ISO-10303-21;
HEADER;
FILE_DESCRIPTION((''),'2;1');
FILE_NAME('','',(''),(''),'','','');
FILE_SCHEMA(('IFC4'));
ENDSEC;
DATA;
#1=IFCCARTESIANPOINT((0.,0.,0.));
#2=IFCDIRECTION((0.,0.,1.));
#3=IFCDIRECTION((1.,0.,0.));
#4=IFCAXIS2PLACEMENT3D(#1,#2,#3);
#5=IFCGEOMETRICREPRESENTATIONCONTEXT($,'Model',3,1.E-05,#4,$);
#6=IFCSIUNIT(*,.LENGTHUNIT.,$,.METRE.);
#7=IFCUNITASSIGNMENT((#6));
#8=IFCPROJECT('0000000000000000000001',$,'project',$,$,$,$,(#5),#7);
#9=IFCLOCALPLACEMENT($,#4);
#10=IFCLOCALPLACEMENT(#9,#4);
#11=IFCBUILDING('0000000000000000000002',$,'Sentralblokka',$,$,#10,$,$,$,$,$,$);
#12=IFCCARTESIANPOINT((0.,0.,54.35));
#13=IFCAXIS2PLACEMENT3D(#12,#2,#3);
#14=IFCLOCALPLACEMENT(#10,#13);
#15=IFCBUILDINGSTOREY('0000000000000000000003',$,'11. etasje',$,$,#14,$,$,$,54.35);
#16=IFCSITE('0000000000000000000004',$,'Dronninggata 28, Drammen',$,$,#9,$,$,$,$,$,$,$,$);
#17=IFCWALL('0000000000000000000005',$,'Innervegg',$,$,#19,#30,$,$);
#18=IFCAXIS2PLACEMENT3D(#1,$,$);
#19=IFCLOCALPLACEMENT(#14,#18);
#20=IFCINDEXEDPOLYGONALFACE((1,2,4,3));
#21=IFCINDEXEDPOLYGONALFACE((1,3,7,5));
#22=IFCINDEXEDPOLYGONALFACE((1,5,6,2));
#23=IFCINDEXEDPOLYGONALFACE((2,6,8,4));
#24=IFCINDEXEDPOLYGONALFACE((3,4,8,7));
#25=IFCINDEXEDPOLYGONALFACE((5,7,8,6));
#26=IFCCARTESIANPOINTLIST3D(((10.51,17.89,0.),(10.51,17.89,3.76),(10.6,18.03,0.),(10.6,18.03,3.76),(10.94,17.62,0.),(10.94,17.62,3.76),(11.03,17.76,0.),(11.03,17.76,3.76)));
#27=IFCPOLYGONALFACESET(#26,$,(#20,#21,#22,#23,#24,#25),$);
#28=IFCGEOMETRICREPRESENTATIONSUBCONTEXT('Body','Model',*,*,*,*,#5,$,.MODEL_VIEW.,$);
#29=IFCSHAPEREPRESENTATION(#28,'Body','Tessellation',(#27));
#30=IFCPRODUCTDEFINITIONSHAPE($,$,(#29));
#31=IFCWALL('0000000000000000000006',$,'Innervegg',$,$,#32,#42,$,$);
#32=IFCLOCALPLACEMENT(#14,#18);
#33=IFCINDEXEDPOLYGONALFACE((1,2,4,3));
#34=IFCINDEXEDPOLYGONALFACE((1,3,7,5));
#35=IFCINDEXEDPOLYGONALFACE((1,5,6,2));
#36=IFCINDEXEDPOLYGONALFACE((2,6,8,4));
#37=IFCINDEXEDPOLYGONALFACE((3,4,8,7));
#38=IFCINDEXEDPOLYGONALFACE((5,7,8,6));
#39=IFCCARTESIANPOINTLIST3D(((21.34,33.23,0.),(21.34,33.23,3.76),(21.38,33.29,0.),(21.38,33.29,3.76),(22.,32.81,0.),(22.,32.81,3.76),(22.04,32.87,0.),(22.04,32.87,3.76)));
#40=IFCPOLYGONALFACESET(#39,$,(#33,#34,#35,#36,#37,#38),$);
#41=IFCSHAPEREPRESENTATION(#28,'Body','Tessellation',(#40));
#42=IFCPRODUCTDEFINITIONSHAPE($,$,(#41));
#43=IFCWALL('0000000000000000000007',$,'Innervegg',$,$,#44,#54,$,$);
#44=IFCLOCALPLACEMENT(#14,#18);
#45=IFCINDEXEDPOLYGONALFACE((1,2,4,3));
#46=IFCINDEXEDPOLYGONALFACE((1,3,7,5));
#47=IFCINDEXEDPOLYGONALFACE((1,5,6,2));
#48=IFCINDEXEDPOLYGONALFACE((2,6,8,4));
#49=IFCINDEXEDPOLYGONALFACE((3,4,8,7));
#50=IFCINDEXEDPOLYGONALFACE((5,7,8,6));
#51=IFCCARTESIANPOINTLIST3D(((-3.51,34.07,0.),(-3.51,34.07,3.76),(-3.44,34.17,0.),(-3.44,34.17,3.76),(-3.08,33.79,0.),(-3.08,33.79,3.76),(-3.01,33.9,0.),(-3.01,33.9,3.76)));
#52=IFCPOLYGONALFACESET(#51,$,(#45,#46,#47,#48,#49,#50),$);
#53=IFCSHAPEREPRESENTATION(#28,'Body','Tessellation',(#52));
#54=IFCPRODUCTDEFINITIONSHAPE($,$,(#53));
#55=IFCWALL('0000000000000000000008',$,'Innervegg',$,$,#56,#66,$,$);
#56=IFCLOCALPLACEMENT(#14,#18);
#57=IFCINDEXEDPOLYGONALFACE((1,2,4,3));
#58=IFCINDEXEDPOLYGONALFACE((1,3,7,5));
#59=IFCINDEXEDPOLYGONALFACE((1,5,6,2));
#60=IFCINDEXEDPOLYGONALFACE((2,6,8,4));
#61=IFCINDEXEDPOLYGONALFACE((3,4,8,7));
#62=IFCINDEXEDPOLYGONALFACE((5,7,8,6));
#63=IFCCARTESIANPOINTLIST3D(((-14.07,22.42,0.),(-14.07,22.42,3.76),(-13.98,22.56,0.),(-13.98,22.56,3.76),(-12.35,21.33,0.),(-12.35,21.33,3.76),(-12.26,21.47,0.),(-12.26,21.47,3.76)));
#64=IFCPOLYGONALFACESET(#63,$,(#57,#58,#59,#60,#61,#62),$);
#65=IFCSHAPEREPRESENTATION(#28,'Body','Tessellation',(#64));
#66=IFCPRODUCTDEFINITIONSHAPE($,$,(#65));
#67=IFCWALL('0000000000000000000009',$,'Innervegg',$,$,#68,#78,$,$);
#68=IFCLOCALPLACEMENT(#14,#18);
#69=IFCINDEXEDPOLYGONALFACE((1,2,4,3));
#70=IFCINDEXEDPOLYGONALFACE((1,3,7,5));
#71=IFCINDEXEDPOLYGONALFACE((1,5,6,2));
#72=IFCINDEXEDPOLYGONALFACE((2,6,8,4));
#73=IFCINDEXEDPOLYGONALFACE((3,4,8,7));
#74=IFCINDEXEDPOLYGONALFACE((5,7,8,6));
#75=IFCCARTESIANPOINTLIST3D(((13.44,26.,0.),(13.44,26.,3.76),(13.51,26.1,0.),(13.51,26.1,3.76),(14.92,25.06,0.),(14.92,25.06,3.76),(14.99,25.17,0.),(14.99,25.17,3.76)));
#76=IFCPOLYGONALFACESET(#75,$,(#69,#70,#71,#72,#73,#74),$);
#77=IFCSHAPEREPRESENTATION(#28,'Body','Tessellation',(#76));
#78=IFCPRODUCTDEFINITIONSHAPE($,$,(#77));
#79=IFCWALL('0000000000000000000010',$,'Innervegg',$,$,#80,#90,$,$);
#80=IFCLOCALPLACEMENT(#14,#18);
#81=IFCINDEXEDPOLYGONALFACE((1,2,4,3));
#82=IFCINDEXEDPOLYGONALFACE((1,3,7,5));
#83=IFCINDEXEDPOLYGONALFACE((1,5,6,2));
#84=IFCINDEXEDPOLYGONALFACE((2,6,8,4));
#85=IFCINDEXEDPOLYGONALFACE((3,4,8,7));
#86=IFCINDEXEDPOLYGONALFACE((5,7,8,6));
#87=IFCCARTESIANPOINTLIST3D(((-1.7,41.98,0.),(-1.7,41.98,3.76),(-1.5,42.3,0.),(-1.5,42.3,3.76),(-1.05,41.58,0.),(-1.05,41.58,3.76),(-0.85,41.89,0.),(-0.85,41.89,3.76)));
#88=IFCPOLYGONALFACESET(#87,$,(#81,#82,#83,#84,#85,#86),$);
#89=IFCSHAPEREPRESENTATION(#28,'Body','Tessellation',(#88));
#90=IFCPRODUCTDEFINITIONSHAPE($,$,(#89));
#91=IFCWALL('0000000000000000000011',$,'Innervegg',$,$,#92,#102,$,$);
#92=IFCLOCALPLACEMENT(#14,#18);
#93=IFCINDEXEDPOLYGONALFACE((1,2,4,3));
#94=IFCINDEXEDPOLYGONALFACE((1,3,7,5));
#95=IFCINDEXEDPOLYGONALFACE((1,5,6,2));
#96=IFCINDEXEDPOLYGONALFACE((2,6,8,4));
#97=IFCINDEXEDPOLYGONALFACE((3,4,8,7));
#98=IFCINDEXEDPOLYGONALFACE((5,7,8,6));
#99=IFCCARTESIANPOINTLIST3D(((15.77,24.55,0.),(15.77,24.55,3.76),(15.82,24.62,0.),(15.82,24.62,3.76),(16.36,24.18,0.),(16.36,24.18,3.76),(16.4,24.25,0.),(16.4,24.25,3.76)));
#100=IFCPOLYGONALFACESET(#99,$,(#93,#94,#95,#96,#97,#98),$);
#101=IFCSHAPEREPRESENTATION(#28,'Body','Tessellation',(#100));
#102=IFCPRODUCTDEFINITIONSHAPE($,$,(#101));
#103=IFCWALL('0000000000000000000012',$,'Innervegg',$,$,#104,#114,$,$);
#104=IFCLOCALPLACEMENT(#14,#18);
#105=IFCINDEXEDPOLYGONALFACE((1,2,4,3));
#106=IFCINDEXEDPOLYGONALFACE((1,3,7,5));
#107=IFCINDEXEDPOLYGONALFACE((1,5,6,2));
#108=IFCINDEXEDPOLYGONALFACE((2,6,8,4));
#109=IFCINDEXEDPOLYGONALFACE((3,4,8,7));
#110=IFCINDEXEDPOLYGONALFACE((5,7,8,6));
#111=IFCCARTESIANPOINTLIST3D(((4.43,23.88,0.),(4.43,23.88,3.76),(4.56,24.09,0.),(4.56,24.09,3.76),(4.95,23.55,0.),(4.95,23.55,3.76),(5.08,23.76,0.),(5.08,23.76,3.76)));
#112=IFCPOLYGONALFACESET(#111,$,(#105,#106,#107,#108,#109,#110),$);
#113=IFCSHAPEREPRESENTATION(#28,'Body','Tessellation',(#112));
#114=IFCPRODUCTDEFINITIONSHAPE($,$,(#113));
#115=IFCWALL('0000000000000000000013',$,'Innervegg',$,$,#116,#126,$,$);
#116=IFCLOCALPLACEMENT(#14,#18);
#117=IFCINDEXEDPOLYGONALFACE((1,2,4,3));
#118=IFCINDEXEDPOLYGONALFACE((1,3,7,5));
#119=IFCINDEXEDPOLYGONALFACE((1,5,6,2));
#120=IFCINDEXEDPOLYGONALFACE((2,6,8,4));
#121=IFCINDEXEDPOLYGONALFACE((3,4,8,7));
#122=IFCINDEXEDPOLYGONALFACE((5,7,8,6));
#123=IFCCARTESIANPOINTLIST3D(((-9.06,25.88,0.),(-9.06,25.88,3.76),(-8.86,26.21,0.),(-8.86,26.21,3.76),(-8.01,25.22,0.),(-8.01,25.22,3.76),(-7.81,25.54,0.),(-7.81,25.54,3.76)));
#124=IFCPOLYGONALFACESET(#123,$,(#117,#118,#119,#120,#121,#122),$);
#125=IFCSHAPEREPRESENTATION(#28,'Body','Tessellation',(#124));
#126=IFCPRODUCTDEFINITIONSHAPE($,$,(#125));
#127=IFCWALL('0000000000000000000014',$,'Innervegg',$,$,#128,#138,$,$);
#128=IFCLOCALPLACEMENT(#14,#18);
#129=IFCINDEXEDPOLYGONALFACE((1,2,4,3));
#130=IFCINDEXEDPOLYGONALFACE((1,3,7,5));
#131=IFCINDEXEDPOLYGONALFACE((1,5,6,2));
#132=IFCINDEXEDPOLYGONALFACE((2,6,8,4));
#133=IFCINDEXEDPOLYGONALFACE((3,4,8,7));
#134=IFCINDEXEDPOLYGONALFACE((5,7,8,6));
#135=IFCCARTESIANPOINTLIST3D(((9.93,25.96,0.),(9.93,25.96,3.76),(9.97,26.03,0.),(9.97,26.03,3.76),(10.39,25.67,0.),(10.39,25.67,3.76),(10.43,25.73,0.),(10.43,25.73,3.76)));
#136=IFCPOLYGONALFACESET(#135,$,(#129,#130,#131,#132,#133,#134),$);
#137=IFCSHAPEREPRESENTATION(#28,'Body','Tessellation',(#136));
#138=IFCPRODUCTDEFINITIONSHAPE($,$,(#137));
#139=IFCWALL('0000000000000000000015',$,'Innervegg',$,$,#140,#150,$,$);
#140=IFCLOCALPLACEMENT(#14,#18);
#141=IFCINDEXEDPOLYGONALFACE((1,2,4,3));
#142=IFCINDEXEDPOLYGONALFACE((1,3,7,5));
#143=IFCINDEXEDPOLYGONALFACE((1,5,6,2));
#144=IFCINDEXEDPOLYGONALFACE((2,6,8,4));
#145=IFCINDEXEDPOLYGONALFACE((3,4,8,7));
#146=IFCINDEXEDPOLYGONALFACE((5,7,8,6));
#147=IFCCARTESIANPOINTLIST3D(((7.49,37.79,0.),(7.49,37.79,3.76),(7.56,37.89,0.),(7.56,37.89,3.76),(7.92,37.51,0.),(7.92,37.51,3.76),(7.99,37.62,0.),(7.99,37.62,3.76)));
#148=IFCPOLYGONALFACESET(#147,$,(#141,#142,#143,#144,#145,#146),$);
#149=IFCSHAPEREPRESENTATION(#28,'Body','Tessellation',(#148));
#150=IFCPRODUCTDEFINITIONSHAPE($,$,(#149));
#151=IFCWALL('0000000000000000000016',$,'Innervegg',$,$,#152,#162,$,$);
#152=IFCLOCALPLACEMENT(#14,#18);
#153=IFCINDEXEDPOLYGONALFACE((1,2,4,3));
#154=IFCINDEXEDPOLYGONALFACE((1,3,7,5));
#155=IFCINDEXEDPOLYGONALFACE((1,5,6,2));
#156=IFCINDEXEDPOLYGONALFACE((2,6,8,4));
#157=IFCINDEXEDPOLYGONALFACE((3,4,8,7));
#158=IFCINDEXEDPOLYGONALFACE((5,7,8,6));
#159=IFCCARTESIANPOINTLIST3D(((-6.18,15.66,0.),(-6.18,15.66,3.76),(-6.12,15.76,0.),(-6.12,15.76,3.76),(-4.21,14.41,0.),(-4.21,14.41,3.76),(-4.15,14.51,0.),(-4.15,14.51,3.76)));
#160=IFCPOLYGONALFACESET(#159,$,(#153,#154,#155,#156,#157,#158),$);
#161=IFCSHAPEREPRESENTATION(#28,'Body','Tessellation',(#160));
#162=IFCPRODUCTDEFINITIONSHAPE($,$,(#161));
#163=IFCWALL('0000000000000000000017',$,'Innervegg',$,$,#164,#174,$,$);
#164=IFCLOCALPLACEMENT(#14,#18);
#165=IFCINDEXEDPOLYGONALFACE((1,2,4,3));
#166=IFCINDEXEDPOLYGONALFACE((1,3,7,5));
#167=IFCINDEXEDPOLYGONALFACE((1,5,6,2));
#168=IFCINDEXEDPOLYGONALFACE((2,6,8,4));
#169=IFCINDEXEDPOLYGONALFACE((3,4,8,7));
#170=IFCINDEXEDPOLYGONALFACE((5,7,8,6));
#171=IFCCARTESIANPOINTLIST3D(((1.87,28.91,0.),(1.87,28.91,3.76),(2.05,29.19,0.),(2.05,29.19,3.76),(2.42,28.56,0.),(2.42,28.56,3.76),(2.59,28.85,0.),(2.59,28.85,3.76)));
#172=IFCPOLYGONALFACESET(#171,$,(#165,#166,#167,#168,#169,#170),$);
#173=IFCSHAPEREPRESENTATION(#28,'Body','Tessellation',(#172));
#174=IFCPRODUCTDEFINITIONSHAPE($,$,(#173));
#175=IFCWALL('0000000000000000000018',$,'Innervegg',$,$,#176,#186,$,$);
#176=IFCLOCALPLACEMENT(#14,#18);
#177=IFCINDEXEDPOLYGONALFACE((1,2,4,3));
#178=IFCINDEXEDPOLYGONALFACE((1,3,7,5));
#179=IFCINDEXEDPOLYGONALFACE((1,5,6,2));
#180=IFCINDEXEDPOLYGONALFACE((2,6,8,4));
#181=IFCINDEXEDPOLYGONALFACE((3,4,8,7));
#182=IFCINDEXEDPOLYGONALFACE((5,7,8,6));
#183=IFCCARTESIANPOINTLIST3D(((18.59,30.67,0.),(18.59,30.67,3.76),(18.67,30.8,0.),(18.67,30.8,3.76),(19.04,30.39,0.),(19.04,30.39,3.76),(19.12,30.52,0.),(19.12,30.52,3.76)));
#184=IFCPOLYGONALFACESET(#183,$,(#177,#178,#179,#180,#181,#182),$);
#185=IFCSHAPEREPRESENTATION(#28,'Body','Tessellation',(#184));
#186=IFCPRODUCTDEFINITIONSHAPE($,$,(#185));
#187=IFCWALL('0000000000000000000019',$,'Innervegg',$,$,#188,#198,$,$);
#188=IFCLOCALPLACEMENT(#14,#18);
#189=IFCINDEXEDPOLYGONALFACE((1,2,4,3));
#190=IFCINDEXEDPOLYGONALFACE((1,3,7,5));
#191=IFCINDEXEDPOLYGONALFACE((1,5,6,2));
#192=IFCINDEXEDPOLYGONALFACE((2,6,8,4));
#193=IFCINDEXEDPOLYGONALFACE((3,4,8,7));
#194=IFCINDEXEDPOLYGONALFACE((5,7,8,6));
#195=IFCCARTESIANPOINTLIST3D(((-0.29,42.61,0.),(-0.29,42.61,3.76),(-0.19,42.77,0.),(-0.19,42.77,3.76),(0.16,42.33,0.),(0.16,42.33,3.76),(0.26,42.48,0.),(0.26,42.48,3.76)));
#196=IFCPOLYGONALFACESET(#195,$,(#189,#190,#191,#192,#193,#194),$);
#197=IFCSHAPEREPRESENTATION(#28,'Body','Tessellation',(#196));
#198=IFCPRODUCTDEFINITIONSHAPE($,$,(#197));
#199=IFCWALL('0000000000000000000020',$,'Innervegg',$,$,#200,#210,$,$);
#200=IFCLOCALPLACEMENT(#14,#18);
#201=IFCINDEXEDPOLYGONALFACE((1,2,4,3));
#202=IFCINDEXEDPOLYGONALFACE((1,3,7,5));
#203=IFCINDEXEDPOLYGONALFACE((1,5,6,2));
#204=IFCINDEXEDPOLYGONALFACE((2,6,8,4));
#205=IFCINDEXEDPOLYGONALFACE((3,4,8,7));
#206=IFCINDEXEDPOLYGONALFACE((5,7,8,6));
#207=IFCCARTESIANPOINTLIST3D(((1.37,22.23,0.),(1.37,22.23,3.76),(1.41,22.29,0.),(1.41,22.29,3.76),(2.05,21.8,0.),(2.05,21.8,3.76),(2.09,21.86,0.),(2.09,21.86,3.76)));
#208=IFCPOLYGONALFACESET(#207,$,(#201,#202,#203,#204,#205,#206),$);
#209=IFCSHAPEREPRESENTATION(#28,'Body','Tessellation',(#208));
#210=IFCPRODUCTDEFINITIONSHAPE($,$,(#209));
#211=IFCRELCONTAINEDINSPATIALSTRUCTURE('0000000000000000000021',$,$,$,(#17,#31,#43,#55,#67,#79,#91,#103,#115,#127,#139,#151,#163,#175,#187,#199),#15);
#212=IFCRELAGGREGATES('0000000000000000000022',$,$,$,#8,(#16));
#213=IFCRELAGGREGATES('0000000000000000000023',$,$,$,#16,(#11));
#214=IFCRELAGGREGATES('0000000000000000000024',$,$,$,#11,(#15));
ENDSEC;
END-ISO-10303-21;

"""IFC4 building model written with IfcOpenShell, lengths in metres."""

from ifc_helpers import new_model, si_unit, frame, origin_with_axes, place, context, subcontext, project, spatial, polyline, outline, extrude, element, save


model = new_model("IFC4")

# Units and contexts
model_context = context("Model", 3, precision=1e-05, world=origin_with_axes())
body_context = subcontext(model_context, "Body", "Model", "MODEL_VIEW")
ifc_project = project(units=[si_unit("LENGTHUNIT", "METRE")], contexts=[model_context])

# Site, building, storey
site_placement = place(None, origin_with_axes())
site = spatial("IfcSite", under=ifc_project, at=site_placement, Name="Dronninggata 28, Drammen")
building_placement = place(site_placement, origin_with_axes())
building = spatial("IfcBuilding", under=site, at=building_placement, Name="Sentralblokka")
storey_placement = place(building_placement, frame((0.0, 0.0, 54.35), z_axis=(0.0, 0.0, 1.0), x_axis=(1.0, 0.0, 0.0)))
storey = spatial("IfcBuildingStorey", under=building, at=storey_placement, Name="11. etasje", Elevation=54.35)

# Walls
wall_1_placement = place(storey_placement, frame((0.0, 0.0, -54.35), z_axis=(0.0, 0.0, 1.0), x_axis=(1.0, 0.0, 0.0)))
element("IfcWall", 1, at=wall_1_placement, inside=storey, Name="Innervegg", context=body_context, shape_type="SweptSolid", body=[
    extrude(outline(polyline([(11.03, 17.76), (10.94, 17.62), (10.51, 17.89), (10.6, 18.03), (11.03, 17.76)])), frame((0.0, 0.0, 54.35)), (0.0, 0.0, 1.0), 3.76),
])
wall_2_placement = place(storey_placement, frame((0.0, 0.0, -54.35), z_axis=(0.0, 0.0, 1.0), x_axis=(1.0, 0.0, 0.0)))
element("IfcWall", 2, at=wall_2_placement, inside=storey, Name="Innervegg", context=body_context, shape_type="SweptSolid", body=[
    extrude(outline(polyline([(22.04, 32.87), (22.0, 32.81), (21.34, 33.23), (21.38, 33.29), (22.04, 32.87)])), frame((0.0, 0.0, 54.35)), (0.0, 0.0, 1.0), 3.76),
])
wall_3_placement = place(storey_placement, frame((0.0, 0.0, -54.35), z_axis=(0.0, 0.0, 1.0), x_axis=(1.0, 0.0, 0.0)))
element("IfcWall", 3, at=wall_3_placement, inside=storey, Name="Innervegg", context=body_context, shape_type="SweptSolid", body=[
    extrude(outline(polyline([(-3.01, 33.9), (-3.08, 33.79), (-3.51, 34.07), (-3.44, 34.17), (-3.01, 33.9)])), frame((0.0, 0.0, 54.35)), (0.0, 0.0, 1.0), 3.76),
])
wall_4_placement = place(storey_placement, frame((0.0, 0.0, -54.35), z_axis=(0.0, 0.0, 1.0), x_axis=(1.0, 0.0, 0.0)))
element("IfcWall", 4, at=wall_4_placement, inside=storey, Name="Innervegg", context=body_context, shape_type="SweptSolid", body=[
    extrude(outline(polyline([(-12.26, 21.47), (-12.35, 21.33), (-14.07, 22.42), (-13.98, 22.56), (-12.26, 21.47)])), frame((0.0, 0.0, 54.35)), (0.0, 0.0, 1.0), 3.76),
])
wall_5_placement = place(storey_placement, frame((0.0, 0.0, -54.35), z_axis=(0.0, 0.0, 1.0), x_axis=(1.0, 0.0, 0.0)))
element("IfcWall", 5, at=wall_5_placement, inside=storey, Name="Innervegg", context=body_context, shape_type="SweptSolid", body=[
    extrude(outline(polyline([(14.99, 25.17), (14.92, 25.06), (13.44, 26.0), (13.51, 26.1), (14.99, 25.17)])), frame((0.0, 0.0, 54.35)), (0.0, 0.0, 1.0), 3.76),
])
wall_6_placement = place(storey_placement, frame((0.0, 0.0, -54.35), z_axis=(0.0, 0.0, 1.0), x_axis=(1.0, 0.0, 0.0)))
element("IfcWall", 6, at=wall_6_placement, inside=storey, Name="Innervegg", context=body_context, shape_type="SweptSolid", body=[
    extrude(outline(polyline([(-0.85, 41.89), (-1.05, 41.58), (-1.7, 41.98), (-1.5, 42.3), (-0.85, 41.89)])), frame((0.0, 0.0, 54.35)), (0.0, 0.0, 1.0), 3.76),
])
wall_7_placement = place(storey_placement, frame((0.0, 0.0, -54.35), z_axis=(0.0, 0.0, 1.0), x_axis=(1.0, 0.0, 0.0)))
element("IfcWall", 7, at=wall_7_placement, inside=storey, Name="Innervegg", context=body_context, shape_type="SweptSolid", body=[
    extrude(outline(polyline([(16.4, 24.25), (16.36, 24.18), (15.77, 24.55), (15.82, 24.62), (16.4, 24.25)])), frame((0.0, 0.0, 54.35)), (0.0, 0.0, 1.0), 3.76),
])
wall_8_placement = place(storey_placement, frame((0.0, 0.0, -54.35), z_axis=(0.0, 0.0, 1.0), x_axis=(1.0, 0.0, 0.0)))
element("IfcWall", 8, at=wall_8_placement, inside=storey, Name="Innervegg", context=body_context, shape_type="SweptSolid", body=[
    extrude(outline(polyline([(5.08, 23.76), (4.95, 23.55), (4.43, 23.88), (4.56, 24.09), (5.08, 23.76)])), frame((0.0, 0.0, 54.35)), (0.0, 0.0, 1.0), 3.76),
])
wall_9_placement = place(storey_placement, frame((0.0, 0.0, -54.35), z_axis=(0.0, 0.0, 1.0), x_axis=(1.0, 0.0, 0.0)))
element("IfcWall", 9, at=wall_9_placement, inside=storey, Name="Innervegg", context=body_context, shape_type="SweptSolid", body=[
    extrude(outline(polyline([(-7.81, 25.54), (-8.01, 25.22), (-9.06, 25.88), (-8.86, 26.21), (-7.81, 25.54)])), frame((0.0, 0.0, 54.35)), (0.0, 0.0, 1.0), 3.76),
])
wall_10_placement = place(storey_placement, frame((0.0, 0.0, -54.35), z_axis=(0.0, 0.0, 1.0), x_axis=(1.0, 0.0, 0.0)))
element("IfcWall", 10, at=wall_10_placement, inside=storey, Name="Innervegg", context=body_context, shape_type="SweptSolid", body=[
    extrude(outline(polyline([(10.43, 25.73), (10.39, 25.67), (9.93, 25.96), (9.97, 26.03), (10.43, 25.73)])), frame((0.0, 0.0, 54.35)), (0.0, 0.0, 1.0), 3.76),
])
wall_11_placement = place(storey_placement, frame((0.0, 0.0, -54.35), z_axis=(0.0, 0.0, 1.0), x_axis=(1.0, 0.0, 0.0)))
element("IfcWall", 11, at=wall_11_placement, inside=storey, Name="Innervegg", context=body_context, shape_type="SweptSolid", body=[
    extrude(outline(polyline([(7.99, 37.62), (7.92, 37.51), (7.49, 37.79), (7.56, 37.89), (7.99, 37.62)])), frame((0.0, 0.0, 54.35)), (0.0, 0.0, 1.0), 3.76),
])
wall_12_placement = place(storey_placement, frame((0.0, 0.0, -54.35), z_axis=(0.0, 0.0, 1.0), x_axis=(1.0, 0.0, 0.0)))
element("IfcWall", 12, at=wall_12_placement, inside=storey, Name="Innervegg", context=body_context, shape_type="SweptSolid", body=[
    extrude(outline(polyline([(-4.15, 14.51), (-4.21, 14.41), (-6.18, 15.66), (-6.12, 15.76), (-4.15, 14.51)])), frame((0.0, 0.0, 54.35)), (0.0, 0.0, 1.0), 3.76),
])
wall_13_placement = place(storey_placement, frame((0.0, 0.0, -54.35), z_axis=(0.0, 0.0, 1.0), x_axis=(1.0, 0.0, 0.0)))
element("IfcWall", 13, at=wall_13_placement, inside=storey, Name="Innervegg", context=body_context, shape_type="SweptSolid", body=[
    extrude(outline(polyline([(2.59, 28.85), (2.42, 28.56), (1.87, 28.91), (2.05, 29.19), (2.59, 28.85)])), frame((0.0, 0.0, 54.35)), (0.0, 0.0, 1.0), 3.76),
])
wall_14_placement = place(storey_placement, frame((0.0, 0.0, -54.35), z_axis=(0.0, 0.0, 1.0), x_axis=(1.0, 0.0, 0.0)))
element("IfcWall", 14, at=wall_14_placement, inside=storey, Name="Innervegg", context=body_context, shape_type="SweptSolid", body=[
    extrude(outline(polyline([(19.12, 30.52), (19.04, 30.39), (18.59, 30.67), (18.67, 30.8), (19.12, 30.52)])), frame((0.0, 0.0, 54.35)), (0.0, 0.0, 1.0), 3.76),
])
wall_15_placement = place(storey_placement, frame((0.0, 0.0, -54.35), z_axis=(0.0, 0.0, 1.0), x_axis=(1.0, 0.0, 0.0)))
element("IfcWall", 15, at=wall_15_placement, inside=storey, Name="Innervegg", context=body_context, shape_type="SweptSolid", body=[
    extrude(outline(polyline([(0.26, 42.48), (0.16, 42.33), (-0.29, 42.61), (-0.19, 42.77), (0.26, 42.48)])), frame((0.0, 0.0, 54.35)), (0.0, 0.0, 1.0), 3.76),
])
wall_16_placement = place(storey_placement, frame((0.0, 0.0, -54.35), z_axis=(0.0, 0.0, 1.0), x_axis=(1.0, 0.0, 0.0)))
element("IfcWall", 16, at=wall_16_placement, inside=storey, Name="Innervegg", context=body_context, shape_type="SweptSolid", body=[
    extrude(outline(polyline([(2.09, 21.86), (2.05, 21.8), (1.37, 22.23), (1.41, 22.29), (2.09, 21.86)])), frame((0.0, 0.0, 54.35)), (0.0, 0.0, 1.0), 3.76),
])

save(model, "model.ifc")
